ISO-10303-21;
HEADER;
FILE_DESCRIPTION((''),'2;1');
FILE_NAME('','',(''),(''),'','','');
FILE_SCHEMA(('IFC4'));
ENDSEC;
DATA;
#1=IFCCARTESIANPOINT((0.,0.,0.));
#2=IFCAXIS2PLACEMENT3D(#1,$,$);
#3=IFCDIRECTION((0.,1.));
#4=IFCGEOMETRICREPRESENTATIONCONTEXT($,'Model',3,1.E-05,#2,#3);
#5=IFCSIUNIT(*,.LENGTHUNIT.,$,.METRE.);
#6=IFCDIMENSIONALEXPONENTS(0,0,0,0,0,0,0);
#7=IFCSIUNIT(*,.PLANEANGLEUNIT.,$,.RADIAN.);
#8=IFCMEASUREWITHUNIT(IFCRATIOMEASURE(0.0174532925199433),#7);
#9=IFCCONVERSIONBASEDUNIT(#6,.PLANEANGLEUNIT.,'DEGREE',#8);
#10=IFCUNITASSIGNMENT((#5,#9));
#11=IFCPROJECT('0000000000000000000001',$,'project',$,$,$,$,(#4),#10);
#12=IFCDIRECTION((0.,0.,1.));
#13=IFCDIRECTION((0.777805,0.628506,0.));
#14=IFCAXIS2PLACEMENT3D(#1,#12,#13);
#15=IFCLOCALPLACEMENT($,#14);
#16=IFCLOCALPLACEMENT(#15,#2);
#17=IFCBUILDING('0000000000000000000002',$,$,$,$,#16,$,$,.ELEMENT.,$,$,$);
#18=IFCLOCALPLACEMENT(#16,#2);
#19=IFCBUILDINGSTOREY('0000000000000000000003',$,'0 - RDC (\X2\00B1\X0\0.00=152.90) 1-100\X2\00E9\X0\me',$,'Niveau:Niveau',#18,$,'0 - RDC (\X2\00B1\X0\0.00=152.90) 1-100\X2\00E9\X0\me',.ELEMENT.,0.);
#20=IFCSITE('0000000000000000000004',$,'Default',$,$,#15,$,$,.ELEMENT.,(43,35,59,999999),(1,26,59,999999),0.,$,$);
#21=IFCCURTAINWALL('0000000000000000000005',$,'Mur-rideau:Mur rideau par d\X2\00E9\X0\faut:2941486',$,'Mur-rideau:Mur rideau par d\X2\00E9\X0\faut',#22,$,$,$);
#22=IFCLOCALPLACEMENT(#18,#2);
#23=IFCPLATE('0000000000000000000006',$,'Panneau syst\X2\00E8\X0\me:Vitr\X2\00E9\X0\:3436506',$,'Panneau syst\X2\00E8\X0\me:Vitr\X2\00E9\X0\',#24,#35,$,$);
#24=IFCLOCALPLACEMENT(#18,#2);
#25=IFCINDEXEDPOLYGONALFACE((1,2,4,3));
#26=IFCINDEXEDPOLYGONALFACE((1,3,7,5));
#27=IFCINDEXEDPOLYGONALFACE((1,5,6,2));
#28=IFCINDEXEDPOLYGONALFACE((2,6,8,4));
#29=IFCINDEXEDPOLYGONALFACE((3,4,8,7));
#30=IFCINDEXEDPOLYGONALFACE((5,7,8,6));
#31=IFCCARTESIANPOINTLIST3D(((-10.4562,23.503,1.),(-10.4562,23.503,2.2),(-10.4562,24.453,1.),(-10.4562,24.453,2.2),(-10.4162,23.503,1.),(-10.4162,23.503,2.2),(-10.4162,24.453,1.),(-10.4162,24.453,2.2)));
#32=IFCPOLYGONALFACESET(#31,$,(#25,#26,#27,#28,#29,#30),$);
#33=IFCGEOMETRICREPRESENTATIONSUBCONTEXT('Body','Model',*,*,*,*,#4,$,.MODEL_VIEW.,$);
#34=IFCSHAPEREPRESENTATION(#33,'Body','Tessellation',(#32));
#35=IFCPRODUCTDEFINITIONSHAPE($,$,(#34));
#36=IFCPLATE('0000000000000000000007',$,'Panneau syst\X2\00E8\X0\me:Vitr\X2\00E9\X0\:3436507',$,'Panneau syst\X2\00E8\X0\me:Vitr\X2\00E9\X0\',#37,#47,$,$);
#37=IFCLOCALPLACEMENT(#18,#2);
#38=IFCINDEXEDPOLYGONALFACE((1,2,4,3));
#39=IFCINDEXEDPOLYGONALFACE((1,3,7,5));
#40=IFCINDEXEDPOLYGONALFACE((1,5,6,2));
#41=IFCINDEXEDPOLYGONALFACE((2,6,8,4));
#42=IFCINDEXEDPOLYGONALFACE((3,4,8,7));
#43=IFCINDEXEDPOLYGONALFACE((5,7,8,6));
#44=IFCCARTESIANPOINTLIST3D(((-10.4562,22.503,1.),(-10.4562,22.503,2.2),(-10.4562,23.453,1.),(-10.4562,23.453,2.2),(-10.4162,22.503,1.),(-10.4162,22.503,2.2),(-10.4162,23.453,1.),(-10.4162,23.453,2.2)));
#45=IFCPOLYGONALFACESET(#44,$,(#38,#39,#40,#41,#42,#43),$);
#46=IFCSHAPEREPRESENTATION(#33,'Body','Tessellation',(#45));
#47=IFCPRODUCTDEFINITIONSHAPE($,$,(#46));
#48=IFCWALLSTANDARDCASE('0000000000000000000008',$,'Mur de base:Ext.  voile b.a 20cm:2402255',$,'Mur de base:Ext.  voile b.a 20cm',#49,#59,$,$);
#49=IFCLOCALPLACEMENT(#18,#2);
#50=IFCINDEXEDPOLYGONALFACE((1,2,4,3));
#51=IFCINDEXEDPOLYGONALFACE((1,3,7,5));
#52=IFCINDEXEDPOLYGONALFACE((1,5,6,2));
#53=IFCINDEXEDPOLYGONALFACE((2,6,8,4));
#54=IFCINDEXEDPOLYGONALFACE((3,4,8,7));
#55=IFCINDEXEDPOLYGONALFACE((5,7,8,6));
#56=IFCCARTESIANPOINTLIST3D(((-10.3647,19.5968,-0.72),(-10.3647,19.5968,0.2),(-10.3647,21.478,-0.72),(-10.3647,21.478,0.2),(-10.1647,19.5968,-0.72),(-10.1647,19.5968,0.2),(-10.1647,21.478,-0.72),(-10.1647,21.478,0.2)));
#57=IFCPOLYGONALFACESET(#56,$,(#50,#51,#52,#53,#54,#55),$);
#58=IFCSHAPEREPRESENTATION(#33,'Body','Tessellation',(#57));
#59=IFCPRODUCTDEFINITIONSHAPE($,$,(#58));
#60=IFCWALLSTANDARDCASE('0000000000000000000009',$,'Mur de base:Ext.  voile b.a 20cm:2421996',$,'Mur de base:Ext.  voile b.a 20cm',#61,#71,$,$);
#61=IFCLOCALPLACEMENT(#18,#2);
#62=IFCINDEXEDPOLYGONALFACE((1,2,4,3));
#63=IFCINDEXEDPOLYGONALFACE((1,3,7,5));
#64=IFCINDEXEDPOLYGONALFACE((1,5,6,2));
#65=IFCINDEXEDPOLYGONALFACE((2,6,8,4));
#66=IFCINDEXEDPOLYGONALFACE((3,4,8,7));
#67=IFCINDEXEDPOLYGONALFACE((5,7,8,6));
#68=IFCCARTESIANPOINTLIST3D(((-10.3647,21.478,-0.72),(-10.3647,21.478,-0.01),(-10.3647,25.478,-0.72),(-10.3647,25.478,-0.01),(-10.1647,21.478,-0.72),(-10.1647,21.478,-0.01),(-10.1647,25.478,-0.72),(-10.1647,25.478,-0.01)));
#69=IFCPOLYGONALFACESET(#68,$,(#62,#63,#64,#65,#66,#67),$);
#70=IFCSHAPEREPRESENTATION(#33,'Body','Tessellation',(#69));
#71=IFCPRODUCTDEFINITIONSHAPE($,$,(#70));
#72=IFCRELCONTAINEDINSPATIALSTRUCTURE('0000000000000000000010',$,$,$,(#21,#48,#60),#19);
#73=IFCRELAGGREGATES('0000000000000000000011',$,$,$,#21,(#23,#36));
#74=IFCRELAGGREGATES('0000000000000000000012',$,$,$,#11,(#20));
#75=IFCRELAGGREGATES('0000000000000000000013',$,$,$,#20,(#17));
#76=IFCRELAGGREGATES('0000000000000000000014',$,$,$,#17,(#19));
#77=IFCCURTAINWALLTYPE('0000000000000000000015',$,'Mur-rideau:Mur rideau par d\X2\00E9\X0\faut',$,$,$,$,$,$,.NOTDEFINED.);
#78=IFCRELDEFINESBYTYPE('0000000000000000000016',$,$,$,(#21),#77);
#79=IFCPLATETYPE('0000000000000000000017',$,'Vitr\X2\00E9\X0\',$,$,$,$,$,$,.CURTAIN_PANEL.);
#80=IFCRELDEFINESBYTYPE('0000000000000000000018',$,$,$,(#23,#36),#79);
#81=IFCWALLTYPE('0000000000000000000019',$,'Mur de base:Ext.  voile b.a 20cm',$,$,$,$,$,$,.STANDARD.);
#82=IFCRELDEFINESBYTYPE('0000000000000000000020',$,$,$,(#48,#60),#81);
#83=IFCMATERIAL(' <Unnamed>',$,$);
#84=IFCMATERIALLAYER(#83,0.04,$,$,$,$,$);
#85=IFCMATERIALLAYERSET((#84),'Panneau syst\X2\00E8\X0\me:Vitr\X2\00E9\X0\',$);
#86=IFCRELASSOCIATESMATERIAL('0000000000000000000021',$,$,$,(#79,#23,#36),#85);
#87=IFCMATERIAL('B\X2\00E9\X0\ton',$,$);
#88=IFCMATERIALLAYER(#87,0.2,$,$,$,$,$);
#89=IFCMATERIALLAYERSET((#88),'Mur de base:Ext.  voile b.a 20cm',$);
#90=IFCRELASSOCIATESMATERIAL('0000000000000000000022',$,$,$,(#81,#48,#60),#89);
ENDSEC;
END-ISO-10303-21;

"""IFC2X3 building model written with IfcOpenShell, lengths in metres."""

from ifc_helpers import new_model, entity, si_unit, converted_unit, direction, frame, frame_2d, origin, place, context, subcontext, project, spatial, rectangle, extrude, source, transform, mapped, material, layer, layer_set, layer_usage, type_object, type_shapes, element, aggregate, save


model = new_model("IFC2X3")

# Units and contexts
model_context = context("Model", 3, precision=1e-05, world=origin(), true_north=direction((0.0, 1.0)))
body_context = subcontext(model_context, "Body", "Model", "MODEL_VIEW")
ifc_project = project(units=[si_unit("LENGTHUNIT", "METRE"), converted_unit("PLANEANGLEUNIT", "DEGREE", entity("IfcRatioMeasure", 0.0174532925199433), si_unit("PLANEANGLEUNIT", "RADIAN"), dimensions=[0, 0, 0, 0, 0, 0, 0])], contexts=[model_context])

# Site, building, storey
site_placement = place(None, frame((0.0, 0.0, 0.0), z_axis=(0.0, 0.0, 1.0), x_axis=(0.777805, 0.628506, 0.0)))
site = spatial("IfcSite", under=ifc_project, at=site_placement, Name="Default", CompositionType="ELEMENT", RefLatitude=(43, 35, 59, 999999), RefLongitude=(1, 26, 59, 999999), RefElevation=0.0)
building_placement = place(site_placement, origin())
building = spatial("IfcBuilding", under=site, at=building_placement, CompositionType="ELEMENT")
storey_placement = place(building_placement, origin())
storey = spatial("IfcBuildingStorey", under=building, at=storey_placement, Name="0 - RDC (±0.00=152.90) 1-100éme", ObjectType="Niveau:Niveau", LongName="0 - RDC (±0.00=152.90) 1-100éme", CompositionType="ELEMENT", Elevation=0.0)

# Curtain wall, plates
curtain_wall_type = type_object("IfcCurtainWallType", Name="Mur-rideau:Mur rideau par défaut", PredefinedType="NOTDEFINED")
curtain_wall_placement = place(storey_placement, origin())
curtain_wall = element("IfcCurtainWall", 1, at=curtain_wall_placement, inside=storey, type_object=curtain_wall_type, Name="Mur-rideau:Mur rideau par défaut:2941486", ObjectType="Mur-rideau:Mur rideau par défaut")
ifc_material_1 = material(Name=" <Unnamed>")
ifc_layer_1 = layer(ifc_material_1, 0.04)
ifc_layer_set_1 = layer_set([ifc_layer_1], Name="Panneau système:Vitré")
ifc_layer_usage_1 = layer_usage(ifc_layer_set_1, "AXIS3", "POSITIVE", 0.0)
plate_type_1 = type_object("IfcPlateType", Name="Vitré", PredefinedType="CURTAIN_PANEL", material=ifc_layer_set_1)
shared_shape_1 = source(origin(), body_context, "Body", "SweptSolid", [
    extrude(rectangle(XDim=0.04, YDim=0.95, at=frame_2d((0.0, 0.0), x_axis=(1.0, 0.0))), frame((0.0, 0.0, 0.0), z_axis=(0.0, 0.0, 1.0), x_axis=(0.0, 1.0, 0.0)), (0.0, 0.0, 1.0), 1.2),
])
type_shapes(plate_type_1, [shared_shape_1])
plate_1_placement = place(curtain_wall_placement, frame((-10.4362, 23.978, 1.0), z_axis=(0.0, 0.0, 1.0), x_axis=(0.0, -1.0, 0.0)))
plate_1 = element("IfcPlate", 2, at=plate_1_placement, type_object=plate_type_1, material=ifc_layer_usage_1, Name="Panneau système:Vitré:3436506", ObjectType="Panneau système:Vitré", context=body_context, shape_type="MappedRepresentation", body=[
    mapped(shared_shape_1, transform((0.0, 0.0, 0.0), scale=1.0)),
])
ifc_layer_usage_2 = layer_usage(ifc_layer_set_1, "AXIS3", "POSITIVE", 0.0)
plate_2_placement = place(curtain_wall_placement, frame((-10.4362, 22.978, 1.0), z_axis=(0.0, 0.0, 1.0), x_axis=(0.0, -1.0, 0.0)))
plate_2 = element("IfcPlate", 3, at=plate_2_placement, type_object=plate_type_1, material=ifc_layer_usage_2, Name="Panneau système:Vitré:3436507", ObjectType="Panneau système:Vitré", context=body_context, shape_type="MappedRepresentation", body=[
    mapped(shared_shape_1, transform((0.0, 0.0, 0.0), scale=1.0)),
])
aggregate(curtain_wall, [plate_1, plate_2])

# Walls
ifc_material_2 = material(Name="Béton")
ifc_layer_2 = layer(ifc_material_2, 0.2)
ifc_layer_set_2 = layer_set([ifc_layer_2], Name="Mur de base:Ext.  voile b.a 20cm")
ifc_layer_usage_3 = layer_usage(ifc_layer_set_2, "AXIS2", "NEGATIVE", 0.1)
wall_type = type_object("IfcWallType", Name="Mur de base:Ext.  voile b.a 20cm", PredefinedType="STANDARD", material=ifc_layer_set_2)
wall_1_placement = place(storey_placement, frame((-10.2647, 21.478, -0.72), z_axis=(0.0, 0.0, 1.0), x_axis=(0.0, -1.0, 0.0)))
element("IfcWallStandardCase", 4, at=wall_1_placement, inside=storey, type_object=wall_type, material=ifc_layer_usage_3, Name="Mur de base:Ext.  voile b.a 20cm:2402255", ObjectType="Mur de base:Ext.  voile b.a 20cm", context=body_context, shape_type="SweptSolid", body=[
    extrude(rectangle(XDim=1.8813, YDim=0.2, at=frame_2d((0.9406, 0.0), x_axis=(-1.0, 0.0))), origin(), (0.0, 0.0, 1.0), 0.92),
])
ifc_layer_usage_4 = layer_usage(ifc_layer_set_2, "AXIS2", "NEGATIVE", 0.1)
wall_2_placement = place(storey_placement, frame((-10.2647, 25.478, -0.72), z_axis=(0.0, 0.0, 1.0), x_axis=(0.0, -1.0, 0.0)))
element("IfcWallStandardCase", 5, at=wall_2_placement, inside=storey, type_object=wall_type, material=ifc_layer_usage_4, Name="Mur de base:Ext.  voile b.a 20cm:2421996", ObjectType="Mur de base:Ext.  voile b.a 20cm", context=body_context, shape_type="SweptSolid", body=[
    extrude(rectangle(XDim=4.0, YDim=0.2, at=frame_2d((2.0, 0.0), x_axis=(-1.0, 0.0))), origin(), (0.0, 0.0, 1.0), 0.71),
])

save(model, "model.ifc")
